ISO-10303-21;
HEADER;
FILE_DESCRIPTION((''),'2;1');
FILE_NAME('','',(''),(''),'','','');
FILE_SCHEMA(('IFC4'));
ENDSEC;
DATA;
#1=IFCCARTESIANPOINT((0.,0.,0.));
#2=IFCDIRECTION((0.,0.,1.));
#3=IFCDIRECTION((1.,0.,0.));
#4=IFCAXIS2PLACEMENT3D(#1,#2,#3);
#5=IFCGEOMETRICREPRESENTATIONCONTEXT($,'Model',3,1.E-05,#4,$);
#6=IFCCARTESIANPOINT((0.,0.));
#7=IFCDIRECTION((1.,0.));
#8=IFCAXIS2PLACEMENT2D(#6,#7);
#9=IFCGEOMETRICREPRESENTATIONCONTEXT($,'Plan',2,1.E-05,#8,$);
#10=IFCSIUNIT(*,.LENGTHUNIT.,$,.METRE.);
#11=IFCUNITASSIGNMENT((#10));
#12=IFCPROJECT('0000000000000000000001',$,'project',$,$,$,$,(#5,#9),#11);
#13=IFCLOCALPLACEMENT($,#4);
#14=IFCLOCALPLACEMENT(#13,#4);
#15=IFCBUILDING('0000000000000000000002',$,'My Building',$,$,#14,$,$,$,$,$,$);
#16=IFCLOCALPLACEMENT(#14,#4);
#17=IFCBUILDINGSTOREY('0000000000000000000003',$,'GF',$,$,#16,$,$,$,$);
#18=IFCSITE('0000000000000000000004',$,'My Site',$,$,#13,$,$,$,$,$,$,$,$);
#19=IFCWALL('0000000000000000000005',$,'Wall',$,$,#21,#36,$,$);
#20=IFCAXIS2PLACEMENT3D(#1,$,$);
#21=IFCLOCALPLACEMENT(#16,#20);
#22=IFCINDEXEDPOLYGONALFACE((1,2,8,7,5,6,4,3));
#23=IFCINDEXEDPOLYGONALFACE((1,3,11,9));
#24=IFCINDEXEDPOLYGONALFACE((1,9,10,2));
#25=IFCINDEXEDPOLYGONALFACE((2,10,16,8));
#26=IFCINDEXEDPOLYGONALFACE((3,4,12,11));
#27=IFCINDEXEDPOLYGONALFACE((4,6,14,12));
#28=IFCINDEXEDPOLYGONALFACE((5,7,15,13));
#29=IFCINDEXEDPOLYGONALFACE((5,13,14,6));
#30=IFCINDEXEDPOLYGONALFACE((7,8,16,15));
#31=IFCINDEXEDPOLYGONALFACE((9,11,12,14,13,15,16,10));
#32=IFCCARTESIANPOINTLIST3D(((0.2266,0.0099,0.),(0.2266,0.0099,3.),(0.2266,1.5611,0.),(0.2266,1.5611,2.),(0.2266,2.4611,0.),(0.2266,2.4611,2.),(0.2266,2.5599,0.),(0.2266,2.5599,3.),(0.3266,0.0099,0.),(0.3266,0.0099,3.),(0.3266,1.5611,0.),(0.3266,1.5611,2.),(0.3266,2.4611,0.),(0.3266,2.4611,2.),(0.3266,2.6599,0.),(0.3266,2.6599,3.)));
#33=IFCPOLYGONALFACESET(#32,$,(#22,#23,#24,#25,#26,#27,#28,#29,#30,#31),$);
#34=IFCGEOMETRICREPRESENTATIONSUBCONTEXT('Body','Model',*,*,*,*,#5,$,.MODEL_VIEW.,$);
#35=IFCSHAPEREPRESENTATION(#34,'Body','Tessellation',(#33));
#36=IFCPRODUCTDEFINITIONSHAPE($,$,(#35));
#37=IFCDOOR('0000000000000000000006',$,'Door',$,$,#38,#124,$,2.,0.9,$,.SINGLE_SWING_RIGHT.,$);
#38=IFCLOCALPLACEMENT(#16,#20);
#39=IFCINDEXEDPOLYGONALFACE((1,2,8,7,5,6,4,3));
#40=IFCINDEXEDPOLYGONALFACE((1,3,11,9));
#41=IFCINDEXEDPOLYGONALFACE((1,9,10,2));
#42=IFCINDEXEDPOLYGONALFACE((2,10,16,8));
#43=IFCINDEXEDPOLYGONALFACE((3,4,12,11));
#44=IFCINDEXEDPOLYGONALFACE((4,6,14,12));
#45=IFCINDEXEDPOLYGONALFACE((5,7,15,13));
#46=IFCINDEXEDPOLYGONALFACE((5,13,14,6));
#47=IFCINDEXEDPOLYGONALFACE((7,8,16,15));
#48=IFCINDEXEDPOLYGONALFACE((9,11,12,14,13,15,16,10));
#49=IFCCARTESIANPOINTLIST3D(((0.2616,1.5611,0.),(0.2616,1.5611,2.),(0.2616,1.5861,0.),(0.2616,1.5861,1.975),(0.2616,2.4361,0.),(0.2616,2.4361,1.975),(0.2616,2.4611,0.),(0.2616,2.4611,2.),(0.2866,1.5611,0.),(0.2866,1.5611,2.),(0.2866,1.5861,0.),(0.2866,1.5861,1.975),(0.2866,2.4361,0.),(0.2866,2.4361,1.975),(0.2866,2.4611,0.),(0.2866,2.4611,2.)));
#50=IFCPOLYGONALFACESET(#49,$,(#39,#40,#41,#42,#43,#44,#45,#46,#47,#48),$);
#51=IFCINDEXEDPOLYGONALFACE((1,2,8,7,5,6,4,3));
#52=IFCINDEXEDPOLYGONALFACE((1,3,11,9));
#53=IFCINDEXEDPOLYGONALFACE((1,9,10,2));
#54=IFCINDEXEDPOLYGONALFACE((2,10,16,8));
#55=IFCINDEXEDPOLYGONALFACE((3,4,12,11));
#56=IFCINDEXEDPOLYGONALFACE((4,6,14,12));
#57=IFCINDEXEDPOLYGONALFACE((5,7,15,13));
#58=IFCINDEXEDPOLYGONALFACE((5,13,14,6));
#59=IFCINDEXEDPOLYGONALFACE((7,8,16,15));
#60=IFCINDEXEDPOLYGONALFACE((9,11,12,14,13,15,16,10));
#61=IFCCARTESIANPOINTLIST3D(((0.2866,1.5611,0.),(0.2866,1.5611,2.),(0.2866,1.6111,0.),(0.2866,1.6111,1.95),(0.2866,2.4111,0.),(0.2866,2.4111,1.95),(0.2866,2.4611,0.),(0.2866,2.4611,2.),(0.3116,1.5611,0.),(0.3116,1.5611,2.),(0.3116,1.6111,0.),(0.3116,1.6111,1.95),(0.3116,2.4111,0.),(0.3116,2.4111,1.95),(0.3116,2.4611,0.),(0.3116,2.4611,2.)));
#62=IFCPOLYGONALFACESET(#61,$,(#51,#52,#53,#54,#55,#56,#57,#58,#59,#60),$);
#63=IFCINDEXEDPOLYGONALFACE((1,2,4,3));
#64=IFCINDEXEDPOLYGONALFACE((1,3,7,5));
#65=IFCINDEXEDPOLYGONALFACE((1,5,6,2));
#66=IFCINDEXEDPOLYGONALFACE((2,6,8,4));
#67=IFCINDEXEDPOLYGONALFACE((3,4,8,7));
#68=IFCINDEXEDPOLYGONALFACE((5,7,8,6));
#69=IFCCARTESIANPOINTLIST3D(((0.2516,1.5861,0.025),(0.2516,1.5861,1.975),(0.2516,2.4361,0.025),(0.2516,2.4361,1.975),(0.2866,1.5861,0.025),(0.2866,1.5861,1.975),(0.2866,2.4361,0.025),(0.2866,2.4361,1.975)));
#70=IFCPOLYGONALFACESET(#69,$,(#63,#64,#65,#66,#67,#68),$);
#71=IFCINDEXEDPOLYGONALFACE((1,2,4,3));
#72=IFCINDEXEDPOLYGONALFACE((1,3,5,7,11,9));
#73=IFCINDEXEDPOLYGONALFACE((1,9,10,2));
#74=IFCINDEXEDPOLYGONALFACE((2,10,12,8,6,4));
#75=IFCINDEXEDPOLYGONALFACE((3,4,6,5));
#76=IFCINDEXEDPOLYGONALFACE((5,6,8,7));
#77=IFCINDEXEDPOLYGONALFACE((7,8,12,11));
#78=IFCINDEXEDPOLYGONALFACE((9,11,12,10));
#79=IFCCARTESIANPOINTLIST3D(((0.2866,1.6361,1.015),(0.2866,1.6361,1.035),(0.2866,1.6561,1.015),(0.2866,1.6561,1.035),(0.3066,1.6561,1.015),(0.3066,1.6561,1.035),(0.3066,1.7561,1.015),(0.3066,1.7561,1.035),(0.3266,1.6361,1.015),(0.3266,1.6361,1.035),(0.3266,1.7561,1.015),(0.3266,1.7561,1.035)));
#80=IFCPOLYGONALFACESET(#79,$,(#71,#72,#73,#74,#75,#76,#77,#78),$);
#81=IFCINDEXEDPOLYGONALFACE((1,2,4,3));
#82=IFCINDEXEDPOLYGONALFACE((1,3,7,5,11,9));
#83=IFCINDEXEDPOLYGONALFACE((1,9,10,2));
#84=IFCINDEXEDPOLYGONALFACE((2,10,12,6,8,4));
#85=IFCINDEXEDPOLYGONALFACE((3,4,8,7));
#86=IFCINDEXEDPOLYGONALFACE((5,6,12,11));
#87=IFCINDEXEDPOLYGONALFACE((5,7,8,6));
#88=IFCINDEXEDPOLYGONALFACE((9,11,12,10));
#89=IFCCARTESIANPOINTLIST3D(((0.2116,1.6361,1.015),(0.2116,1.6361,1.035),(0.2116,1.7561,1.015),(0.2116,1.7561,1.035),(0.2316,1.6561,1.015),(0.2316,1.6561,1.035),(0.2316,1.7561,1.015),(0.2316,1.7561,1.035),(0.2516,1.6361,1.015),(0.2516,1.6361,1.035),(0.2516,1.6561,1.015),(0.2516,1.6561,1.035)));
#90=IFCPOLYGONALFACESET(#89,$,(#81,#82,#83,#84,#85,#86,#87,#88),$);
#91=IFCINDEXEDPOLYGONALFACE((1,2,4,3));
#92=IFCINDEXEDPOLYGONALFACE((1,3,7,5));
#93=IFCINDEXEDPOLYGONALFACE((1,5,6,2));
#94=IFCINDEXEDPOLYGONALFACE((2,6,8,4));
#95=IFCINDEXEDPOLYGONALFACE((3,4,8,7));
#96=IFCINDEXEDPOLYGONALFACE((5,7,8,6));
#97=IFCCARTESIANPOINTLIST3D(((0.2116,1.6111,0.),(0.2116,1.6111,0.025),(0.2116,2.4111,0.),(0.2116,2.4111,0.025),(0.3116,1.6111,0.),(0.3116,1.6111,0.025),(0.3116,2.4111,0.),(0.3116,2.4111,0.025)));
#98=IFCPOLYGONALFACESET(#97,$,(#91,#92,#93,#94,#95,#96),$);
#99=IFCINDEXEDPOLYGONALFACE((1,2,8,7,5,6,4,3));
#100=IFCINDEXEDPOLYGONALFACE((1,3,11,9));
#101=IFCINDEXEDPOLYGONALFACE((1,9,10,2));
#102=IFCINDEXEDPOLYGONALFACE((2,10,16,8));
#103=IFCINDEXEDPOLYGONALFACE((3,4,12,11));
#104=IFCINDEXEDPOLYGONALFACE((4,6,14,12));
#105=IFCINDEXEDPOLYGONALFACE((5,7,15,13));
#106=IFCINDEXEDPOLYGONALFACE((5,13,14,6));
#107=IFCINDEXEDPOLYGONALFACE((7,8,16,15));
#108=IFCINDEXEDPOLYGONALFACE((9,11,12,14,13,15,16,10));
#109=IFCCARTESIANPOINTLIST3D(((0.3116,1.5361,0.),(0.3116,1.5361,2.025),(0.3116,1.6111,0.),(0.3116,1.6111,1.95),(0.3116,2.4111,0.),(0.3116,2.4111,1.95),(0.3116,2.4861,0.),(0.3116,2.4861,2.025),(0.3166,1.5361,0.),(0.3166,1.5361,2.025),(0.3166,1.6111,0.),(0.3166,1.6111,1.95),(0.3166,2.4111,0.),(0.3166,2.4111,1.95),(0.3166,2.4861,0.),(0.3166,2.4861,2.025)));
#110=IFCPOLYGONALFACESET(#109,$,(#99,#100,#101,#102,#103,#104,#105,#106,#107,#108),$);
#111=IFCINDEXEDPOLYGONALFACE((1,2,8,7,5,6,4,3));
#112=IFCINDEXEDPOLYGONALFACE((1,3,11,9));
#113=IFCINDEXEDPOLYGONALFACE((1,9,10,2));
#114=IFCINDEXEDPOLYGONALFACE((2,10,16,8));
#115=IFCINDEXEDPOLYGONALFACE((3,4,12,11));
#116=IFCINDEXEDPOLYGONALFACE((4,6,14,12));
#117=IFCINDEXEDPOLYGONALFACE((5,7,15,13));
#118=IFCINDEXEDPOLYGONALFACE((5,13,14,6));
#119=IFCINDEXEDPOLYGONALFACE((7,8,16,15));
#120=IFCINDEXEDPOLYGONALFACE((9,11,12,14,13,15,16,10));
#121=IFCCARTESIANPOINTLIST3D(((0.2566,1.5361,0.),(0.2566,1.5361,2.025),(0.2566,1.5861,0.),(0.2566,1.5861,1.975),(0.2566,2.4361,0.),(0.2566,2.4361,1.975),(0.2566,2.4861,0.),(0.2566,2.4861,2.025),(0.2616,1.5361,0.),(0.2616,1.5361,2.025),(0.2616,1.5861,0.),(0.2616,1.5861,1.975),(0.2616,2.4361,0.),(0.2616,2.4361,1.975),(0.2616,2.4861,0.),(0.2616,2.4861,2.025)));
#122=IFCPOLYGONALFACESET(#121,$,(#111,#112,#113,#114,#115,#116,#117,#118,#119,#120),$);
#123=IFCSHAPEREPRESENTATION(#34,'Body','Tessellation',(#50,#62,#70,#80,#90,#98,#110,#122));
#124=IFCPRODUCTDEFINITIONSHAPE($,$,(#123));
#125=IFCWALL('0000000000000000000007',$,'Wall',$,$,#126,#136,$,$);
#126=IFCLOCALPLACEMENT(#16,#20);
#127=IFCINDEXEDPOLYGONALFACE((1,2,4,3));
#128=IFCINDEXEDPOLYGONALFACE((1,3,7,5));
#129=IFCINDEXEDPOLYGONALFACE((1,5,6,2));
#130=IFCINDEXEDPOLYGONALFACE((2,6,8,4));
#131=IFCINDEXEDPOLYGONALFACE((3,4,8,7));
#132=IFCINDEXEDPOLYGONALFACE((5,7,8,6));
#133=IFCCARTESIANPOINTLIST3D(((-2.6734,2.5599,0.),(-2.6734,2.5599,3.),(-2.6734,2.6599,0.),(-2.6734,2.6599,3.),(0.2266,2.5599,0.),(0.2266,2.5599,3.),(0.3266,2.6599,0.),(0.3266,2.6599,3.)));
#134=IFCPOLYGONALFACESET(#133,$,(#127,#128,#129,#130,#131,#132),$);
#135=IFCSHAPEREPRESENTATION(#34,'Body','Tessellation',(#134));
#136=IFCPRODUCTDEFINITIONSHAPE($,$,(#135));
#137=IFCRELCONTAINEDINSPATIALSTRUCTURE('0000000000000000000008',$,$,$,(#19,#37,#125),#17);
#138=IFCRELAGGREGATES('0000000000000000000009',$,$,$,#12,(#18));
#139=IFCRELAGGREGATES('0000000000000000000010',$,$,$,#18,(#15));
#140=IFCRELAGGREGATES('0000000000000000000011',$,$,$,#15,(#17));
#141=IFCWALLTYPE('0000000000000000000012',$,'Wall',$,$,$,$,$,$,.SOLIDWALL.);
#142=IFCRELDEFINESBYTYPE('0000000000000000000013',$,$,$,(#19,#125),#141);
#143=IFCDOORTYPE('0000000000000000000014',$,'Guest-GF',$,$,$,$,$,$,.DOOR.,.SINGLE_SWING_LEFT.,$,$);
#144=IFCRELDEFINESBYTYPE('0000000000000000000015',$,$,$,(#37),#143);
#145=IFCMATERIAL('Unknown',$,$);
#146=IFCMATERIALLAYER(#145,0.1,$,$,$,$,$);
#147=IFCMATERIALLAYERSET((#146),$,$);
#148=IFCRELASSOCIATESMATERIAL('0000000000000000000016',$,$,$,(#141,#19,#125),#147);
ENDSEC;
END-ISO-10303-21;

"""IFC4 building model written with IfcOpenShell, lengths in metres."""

from ifc_helpers import new_model, entity, si_unit, frame, origin_with_axes, origin_2d_with_axis, place, context, subcontext, project, spatial, line, indexed_curve, outline, extrude, shape, source, transform, mapped, material, layer, layer_set, layer_usage, type_object, type_shapes, element, fill, save


model = new_model("IFC4")

# Units and contexts
model_context = context("Model", 3, precision=1e-05, world=origin_with_axes())
plan_context = context("Plan", 2, precision=1e-05, world=origin_2d_with_axis())
body_context_1 = subcontext(model_context, "Body", "Model", "MODEL_VIEW")
body_context_2 = subcontext(plan_context, "Body", "Plan", "PLAN_VIEW")
ifc_project = project(units=[si_unit("LENGTHUNIT", "METRE")], contexts=[model_context, plan_context])

# Site, building, storey
site_placement = place(None, origin_with_axes())
site = spatial("IfcSite", under=ifc_project, at=site_placement, Name="My Site")
building_placement = place(site_placement, origin_with_axes())
building = spatial("IfcBuilding", under=site, at=building_placement, Name="My Building")
storey_placement = place(building_placement, origin_with_axes())
storey = spatial("IfcBuildingStorey", under=building, at=storey_placement, Name="GF")

# Shared definitions
ifc_material_1 = material(Name="Unknown")

# Shared definitions
ifc_layer_1 = layer(ifc_material_1, 0.1)
ifc_layer_set_1 = layer_set([ifc_layer_1])
wall_type = type_object("IfcWallType", Name="Wall", PredefinedType="SOLIDWALL", material=ifc_layer_set_1)

# Wall, opening, door
ifc_layer_usage_1 = layer_usage(ifc_layer_set_1, "AXIS2", "POSITIVE", 0.0)
wall_1_placement = place(storey_placement, frame((0.3266, 0.0099, 0.0), z_axis=(0.0, 0.0, 1.0), x_axis=(0.0, 1.0, 0.0)))
wall_1 = element("IfcWall", 1, at=wall_1_placement, inside=storey, type_object=wall_type, material=ifc_layer_usage_1, Name="Wall", context=body_context_1, shape_type="SweptSolid", body=[
    extrude(outline(indexed_curve([(0.0, 0.0), (0.0, 0.1), (2.55, 0.1), (2.65, 0.0)], segments=[line(1, 2, 3, 4, 1)])), origin_with_axes(), (0.0, 0.0, 1.0), 3.0),
])
shared_shape_1 = source(origin_with_axes(), body_context_1, "Body", "SweptSolid", [
    extrude(outline(indexed_curve([(0.0, 0.0), (0.9, 0.0), (0.9, 2.0), (0.0, 2.0)], segments=[line(1, 2, 3, 4, 1)])), frame((0.0, -0.6, 0.0), z_axis=(0.0, -1.0, 0.0), x_axis=(1.0, 0.0, 0.0)), (0.0, 0.0, -1.0), 1.2),
])
opening_1_placement = place(wall_1_placement, frame((1.5512, 0.015, 0.0), z_axis=(0.0, 0.0, 1.0), x_axis=(1.0, 0.0, 0.0)))
opening_1 = element("IfcOpeningElement", 2, at=opening_1_placement, cuts=wall_1, PredefinedType="OPENING", context=body_context_1, shape_type="MappedRepresentation", body=[
    mapped(shared_shape_1, transform((0.0, 0.0, 0.0), x_axis=(1.0, 0.0, 0.0), y_axis=(0.0, 1.0, 0.0), z_axis=(0.0, 0.0, 1.0), scale=1.0)),
])
door_type_1 = type_object("IfcDoorType", Name="Guest-GF", OperationType="SINGLE_SWING_LEFT", PredefinedType="DOOR")
shared_shape_2 = source(origin_with_axes(), body_context_1, "Body", "SweptSolid", [
    extrude(outline(indexed_curve([(0.0, 0.0), (0.0, 2.0), (0.9, 2.0), (0.9, 0.0), (0.875, 0.0), (0.875, 1.975), (0.025, 1.975), (0.025, 0.0)], segments=[line(1, 2, 3, 4, 5, 6, 7, 8, 1)])), frame((0.0, 0.025, 0.0), z_axis=(0.0, -1.0, 0.0), x_axis=(1.0, 0.0, 0.0)), (0.0, 0.0, -1.0), 0.025),
    extrude(outline(indexed_curve([(0.0, 0.0), (0.0, 2.0), (0.9, 2.0), (0.9, 0.0), (0.85, 0.0), (0.85, 1.95), (0.05, 1.95), (0.05, 0.0)], segments=[line(1, 2, 3, 4, 5, 6, 7, 8, 1)])), frame((0.0, 0.0, 0.0), z_axis=(0.0, -1.0, 0.0), x_axis=(1.0, 0.0, 0.0)), (0.0, 0.0, -1.0), 0.025),
    extrude(outline(indexed_curve([(0.0, 0.0), (0.85, 0.0), (0.85, 0.035), (0.0, 0.035)], segments=[line(1, 2, 3, 4, 1)])), frame((0.025, 0.025, 0.025), z_axis=(0.0, 0.0, 1.0), x_axis=(1.0, 0.0, 0.0)), (0.0, 0.0, 1.0), 1.95),
    extrude(outline(indexed_curve([(0.0, 0.0), (0.0, -0.04), (0.12, -0.04), (0.12, -0.02), (0.02, -0.02), (0.02, 0.0)], segments=[line(1, 2, 3, 4, 5, 6, 1)])), frame((0.075, 0.025, 1.015), z_axis=(0.0, 0.0, 1.0), x_axis=(1.0, 0.0, 0.0)), (0.0, 0.0, 1.0), 0.02),
    extrude(outline(indexed_curve([(0.0, 0.0), (0.0, 0.04), (0.12, 0.04), (0.12, 0.02), (0.02, 0.02), (0.02, 0.0)], segments=[line(1, 2, 3, 4, 5, 6, 1)])), frame((0.075, 0.06, 1.015), z_axis=(0.0, 0.0, 1.0), x_axis=(1.0, 0.0, 0.0)), (0.0, 0.0, 1.0), 0.02),
    extrude(outline(indexed_curve([(0.0, 0.0), (0.8, 0.0), (0.8, 0.1), (0.0, 0.1)], segments=[line(1, 2, 3, 4, 1)])), frame((0.05, 0.0, 0.0), z_axis=(0.0, 0.0, 1.0), x_axis=(1.0, 0.0, 0.0)), (0.0, 0.0, 1.0), 0.025),
    extrude(outline(indexed_curve([(0.0, 0.0), (0.0, 2.025), (0.95, 2.025), (0.95, 0.0), (0.875, 0.0), (0.875, 1.95), (0.075, 1.95), (0.075, 0.0)], segments=[line(1, 2, 3, 4, 5, 6, 7, 8, 1)])), frame((-0.025, -0.005, 0.0), z_axis=(0.0, -1.0, 0.0), x_axis=(1.0, 0.0, 0.0)), (0.0, 0.0, -1.0), 0.005),
    extrude(outline(indexed_curve([(0.0, 0.0), (0.0, 2.025), (0.95, 2.025), (0.95, 0.0), (0.9, 0.0), (0.9, 1.975), (0.05, 1.975), (0.05, 0.0)], segments=[line(1, 2, 3, 4, 5, 6, 7, 8, 1)])), frame((-0.025, 0.05, 0.0), z_axis=(0.0, -1.0, 0.0), x_axis=(1.0, 0.0, 0.0)), (0.0, 0.0, -1.0), 0.005),
])
shared_shape_3 = source(origin_with_axes(), body_context_2, "Body", "Curve2D", [
    entity("IfcIndexedPolyCurve", entity("IfcCartesianPointList2D", [[0.0, 0.0], [0.0, 0.05], [0.025, 0.05], [0.025, 0.025], [0.05, 0.025], [0.05, 0.0]]), [entity("IfcLineIndex", [1, 2, 3, 4, 5, 6, 1])]),
    entity("IfcIndexedPolyCurve", entity("IfcCartesianPointList2D", [[0.9, 0.0], [0.9, 0.05], [0.875, 0.05], [0.875, 0.025], [0.85, 0.025], [0.85, 0.0]]), [entity("IfcLineIndex", [1, 2, 3, 4, 5, 6, 1])]),
    entity("IfcTrimmedCurve", entity("IfcEllipse", entity("IfcAxis2Placement2D", entity("IfcCartesianPoint", [0.84, 0.05]), entity("IfcDirection", [1.0, 0.0])), 0.815, 0.85), [entity("IfcCartesianPoint", [0.84, 0.9])], [entity("IfcCartesianPoint", [0.025, 0.05])], True, "CARTESIAN"),
    entity("IfcIndexedPolyCurve", entity("IfcCartesianPointList2D", [[0.875, 0.05], [0.84, 0.05], [0.84, 0.9], [0.875, 0.9]]), [entity("IfcLineIndex", [1, 2, 3, 4, 1])]),
])
type_shapes(door_type_1, [shared_shape_2, shared_shape_3])
door_1_placement = place(opening_1_placement, frame((0.0, 0.0, 0.0), z_axis=(0.0, 0.0, 1.0), x_axis=(1.0, 0.0, 0.0)))
door_1 = element("IfcDoor", 3, at=door_1_placement, inside=storey, type_object=door_type_1, Name="Door", OperationType="SINGLE_SWING_RIGHT", OverallHeight=2.0, OverallWidth=0.9, shapes=[
    shape(body_context_1, "Body", "MappedRepresentation", [mapped(shared_shape_2, transform((0.0, 0.0, 0.0), x_axis=(1.0, 0.0, 0.0), y_axis=(0.0, 1.0, 0.0), z_axis=(0.0, 0.0, 1.0), scale=1.0))]),
    shape(body_context_2, "Body", "MappedRepresentation", [mapped(shared_shape_3, transform((0.0, 0.0, 0.0), x_axis=(1.0, 0.0, 0.0), y_axis=(0.0, 1.0, 0.0), z_axis=(0.0, 0.0, 1.0), scale=1.0))]),
])
fill(opening_1, door_1)

# Wall
ifc_layer_usage_2 = layer_usage(ifc_layer_set_1, "AXIS2", "POSITIVE", 0.0)
wall_2_placement = place(storey_placement, frame((0.3266, 2.6599, 0.0), z_axis=(0.0, 0.0, 1.0), x_axis=(-1.0, 0.0, 0.0)))
element("IfcWall", 4, at=wall_2_placement, inside=storey, type_object=wall_type, material=ifc_layer_usage_2, Name="Wall", context=body_context_1, shape_type="SweptSolid", body=[
    extrude(outline(indexed_curve([(0.0, 0.0), (0.1, 0.1), (3.0, 0.1), (3.0, 0.0)], segments=[line(1, 2, 3, 4, 1)])), origin_with_axes(), (0.0, 0.0, 1.0), 3.0),
])

save(model, "model.ifc")
